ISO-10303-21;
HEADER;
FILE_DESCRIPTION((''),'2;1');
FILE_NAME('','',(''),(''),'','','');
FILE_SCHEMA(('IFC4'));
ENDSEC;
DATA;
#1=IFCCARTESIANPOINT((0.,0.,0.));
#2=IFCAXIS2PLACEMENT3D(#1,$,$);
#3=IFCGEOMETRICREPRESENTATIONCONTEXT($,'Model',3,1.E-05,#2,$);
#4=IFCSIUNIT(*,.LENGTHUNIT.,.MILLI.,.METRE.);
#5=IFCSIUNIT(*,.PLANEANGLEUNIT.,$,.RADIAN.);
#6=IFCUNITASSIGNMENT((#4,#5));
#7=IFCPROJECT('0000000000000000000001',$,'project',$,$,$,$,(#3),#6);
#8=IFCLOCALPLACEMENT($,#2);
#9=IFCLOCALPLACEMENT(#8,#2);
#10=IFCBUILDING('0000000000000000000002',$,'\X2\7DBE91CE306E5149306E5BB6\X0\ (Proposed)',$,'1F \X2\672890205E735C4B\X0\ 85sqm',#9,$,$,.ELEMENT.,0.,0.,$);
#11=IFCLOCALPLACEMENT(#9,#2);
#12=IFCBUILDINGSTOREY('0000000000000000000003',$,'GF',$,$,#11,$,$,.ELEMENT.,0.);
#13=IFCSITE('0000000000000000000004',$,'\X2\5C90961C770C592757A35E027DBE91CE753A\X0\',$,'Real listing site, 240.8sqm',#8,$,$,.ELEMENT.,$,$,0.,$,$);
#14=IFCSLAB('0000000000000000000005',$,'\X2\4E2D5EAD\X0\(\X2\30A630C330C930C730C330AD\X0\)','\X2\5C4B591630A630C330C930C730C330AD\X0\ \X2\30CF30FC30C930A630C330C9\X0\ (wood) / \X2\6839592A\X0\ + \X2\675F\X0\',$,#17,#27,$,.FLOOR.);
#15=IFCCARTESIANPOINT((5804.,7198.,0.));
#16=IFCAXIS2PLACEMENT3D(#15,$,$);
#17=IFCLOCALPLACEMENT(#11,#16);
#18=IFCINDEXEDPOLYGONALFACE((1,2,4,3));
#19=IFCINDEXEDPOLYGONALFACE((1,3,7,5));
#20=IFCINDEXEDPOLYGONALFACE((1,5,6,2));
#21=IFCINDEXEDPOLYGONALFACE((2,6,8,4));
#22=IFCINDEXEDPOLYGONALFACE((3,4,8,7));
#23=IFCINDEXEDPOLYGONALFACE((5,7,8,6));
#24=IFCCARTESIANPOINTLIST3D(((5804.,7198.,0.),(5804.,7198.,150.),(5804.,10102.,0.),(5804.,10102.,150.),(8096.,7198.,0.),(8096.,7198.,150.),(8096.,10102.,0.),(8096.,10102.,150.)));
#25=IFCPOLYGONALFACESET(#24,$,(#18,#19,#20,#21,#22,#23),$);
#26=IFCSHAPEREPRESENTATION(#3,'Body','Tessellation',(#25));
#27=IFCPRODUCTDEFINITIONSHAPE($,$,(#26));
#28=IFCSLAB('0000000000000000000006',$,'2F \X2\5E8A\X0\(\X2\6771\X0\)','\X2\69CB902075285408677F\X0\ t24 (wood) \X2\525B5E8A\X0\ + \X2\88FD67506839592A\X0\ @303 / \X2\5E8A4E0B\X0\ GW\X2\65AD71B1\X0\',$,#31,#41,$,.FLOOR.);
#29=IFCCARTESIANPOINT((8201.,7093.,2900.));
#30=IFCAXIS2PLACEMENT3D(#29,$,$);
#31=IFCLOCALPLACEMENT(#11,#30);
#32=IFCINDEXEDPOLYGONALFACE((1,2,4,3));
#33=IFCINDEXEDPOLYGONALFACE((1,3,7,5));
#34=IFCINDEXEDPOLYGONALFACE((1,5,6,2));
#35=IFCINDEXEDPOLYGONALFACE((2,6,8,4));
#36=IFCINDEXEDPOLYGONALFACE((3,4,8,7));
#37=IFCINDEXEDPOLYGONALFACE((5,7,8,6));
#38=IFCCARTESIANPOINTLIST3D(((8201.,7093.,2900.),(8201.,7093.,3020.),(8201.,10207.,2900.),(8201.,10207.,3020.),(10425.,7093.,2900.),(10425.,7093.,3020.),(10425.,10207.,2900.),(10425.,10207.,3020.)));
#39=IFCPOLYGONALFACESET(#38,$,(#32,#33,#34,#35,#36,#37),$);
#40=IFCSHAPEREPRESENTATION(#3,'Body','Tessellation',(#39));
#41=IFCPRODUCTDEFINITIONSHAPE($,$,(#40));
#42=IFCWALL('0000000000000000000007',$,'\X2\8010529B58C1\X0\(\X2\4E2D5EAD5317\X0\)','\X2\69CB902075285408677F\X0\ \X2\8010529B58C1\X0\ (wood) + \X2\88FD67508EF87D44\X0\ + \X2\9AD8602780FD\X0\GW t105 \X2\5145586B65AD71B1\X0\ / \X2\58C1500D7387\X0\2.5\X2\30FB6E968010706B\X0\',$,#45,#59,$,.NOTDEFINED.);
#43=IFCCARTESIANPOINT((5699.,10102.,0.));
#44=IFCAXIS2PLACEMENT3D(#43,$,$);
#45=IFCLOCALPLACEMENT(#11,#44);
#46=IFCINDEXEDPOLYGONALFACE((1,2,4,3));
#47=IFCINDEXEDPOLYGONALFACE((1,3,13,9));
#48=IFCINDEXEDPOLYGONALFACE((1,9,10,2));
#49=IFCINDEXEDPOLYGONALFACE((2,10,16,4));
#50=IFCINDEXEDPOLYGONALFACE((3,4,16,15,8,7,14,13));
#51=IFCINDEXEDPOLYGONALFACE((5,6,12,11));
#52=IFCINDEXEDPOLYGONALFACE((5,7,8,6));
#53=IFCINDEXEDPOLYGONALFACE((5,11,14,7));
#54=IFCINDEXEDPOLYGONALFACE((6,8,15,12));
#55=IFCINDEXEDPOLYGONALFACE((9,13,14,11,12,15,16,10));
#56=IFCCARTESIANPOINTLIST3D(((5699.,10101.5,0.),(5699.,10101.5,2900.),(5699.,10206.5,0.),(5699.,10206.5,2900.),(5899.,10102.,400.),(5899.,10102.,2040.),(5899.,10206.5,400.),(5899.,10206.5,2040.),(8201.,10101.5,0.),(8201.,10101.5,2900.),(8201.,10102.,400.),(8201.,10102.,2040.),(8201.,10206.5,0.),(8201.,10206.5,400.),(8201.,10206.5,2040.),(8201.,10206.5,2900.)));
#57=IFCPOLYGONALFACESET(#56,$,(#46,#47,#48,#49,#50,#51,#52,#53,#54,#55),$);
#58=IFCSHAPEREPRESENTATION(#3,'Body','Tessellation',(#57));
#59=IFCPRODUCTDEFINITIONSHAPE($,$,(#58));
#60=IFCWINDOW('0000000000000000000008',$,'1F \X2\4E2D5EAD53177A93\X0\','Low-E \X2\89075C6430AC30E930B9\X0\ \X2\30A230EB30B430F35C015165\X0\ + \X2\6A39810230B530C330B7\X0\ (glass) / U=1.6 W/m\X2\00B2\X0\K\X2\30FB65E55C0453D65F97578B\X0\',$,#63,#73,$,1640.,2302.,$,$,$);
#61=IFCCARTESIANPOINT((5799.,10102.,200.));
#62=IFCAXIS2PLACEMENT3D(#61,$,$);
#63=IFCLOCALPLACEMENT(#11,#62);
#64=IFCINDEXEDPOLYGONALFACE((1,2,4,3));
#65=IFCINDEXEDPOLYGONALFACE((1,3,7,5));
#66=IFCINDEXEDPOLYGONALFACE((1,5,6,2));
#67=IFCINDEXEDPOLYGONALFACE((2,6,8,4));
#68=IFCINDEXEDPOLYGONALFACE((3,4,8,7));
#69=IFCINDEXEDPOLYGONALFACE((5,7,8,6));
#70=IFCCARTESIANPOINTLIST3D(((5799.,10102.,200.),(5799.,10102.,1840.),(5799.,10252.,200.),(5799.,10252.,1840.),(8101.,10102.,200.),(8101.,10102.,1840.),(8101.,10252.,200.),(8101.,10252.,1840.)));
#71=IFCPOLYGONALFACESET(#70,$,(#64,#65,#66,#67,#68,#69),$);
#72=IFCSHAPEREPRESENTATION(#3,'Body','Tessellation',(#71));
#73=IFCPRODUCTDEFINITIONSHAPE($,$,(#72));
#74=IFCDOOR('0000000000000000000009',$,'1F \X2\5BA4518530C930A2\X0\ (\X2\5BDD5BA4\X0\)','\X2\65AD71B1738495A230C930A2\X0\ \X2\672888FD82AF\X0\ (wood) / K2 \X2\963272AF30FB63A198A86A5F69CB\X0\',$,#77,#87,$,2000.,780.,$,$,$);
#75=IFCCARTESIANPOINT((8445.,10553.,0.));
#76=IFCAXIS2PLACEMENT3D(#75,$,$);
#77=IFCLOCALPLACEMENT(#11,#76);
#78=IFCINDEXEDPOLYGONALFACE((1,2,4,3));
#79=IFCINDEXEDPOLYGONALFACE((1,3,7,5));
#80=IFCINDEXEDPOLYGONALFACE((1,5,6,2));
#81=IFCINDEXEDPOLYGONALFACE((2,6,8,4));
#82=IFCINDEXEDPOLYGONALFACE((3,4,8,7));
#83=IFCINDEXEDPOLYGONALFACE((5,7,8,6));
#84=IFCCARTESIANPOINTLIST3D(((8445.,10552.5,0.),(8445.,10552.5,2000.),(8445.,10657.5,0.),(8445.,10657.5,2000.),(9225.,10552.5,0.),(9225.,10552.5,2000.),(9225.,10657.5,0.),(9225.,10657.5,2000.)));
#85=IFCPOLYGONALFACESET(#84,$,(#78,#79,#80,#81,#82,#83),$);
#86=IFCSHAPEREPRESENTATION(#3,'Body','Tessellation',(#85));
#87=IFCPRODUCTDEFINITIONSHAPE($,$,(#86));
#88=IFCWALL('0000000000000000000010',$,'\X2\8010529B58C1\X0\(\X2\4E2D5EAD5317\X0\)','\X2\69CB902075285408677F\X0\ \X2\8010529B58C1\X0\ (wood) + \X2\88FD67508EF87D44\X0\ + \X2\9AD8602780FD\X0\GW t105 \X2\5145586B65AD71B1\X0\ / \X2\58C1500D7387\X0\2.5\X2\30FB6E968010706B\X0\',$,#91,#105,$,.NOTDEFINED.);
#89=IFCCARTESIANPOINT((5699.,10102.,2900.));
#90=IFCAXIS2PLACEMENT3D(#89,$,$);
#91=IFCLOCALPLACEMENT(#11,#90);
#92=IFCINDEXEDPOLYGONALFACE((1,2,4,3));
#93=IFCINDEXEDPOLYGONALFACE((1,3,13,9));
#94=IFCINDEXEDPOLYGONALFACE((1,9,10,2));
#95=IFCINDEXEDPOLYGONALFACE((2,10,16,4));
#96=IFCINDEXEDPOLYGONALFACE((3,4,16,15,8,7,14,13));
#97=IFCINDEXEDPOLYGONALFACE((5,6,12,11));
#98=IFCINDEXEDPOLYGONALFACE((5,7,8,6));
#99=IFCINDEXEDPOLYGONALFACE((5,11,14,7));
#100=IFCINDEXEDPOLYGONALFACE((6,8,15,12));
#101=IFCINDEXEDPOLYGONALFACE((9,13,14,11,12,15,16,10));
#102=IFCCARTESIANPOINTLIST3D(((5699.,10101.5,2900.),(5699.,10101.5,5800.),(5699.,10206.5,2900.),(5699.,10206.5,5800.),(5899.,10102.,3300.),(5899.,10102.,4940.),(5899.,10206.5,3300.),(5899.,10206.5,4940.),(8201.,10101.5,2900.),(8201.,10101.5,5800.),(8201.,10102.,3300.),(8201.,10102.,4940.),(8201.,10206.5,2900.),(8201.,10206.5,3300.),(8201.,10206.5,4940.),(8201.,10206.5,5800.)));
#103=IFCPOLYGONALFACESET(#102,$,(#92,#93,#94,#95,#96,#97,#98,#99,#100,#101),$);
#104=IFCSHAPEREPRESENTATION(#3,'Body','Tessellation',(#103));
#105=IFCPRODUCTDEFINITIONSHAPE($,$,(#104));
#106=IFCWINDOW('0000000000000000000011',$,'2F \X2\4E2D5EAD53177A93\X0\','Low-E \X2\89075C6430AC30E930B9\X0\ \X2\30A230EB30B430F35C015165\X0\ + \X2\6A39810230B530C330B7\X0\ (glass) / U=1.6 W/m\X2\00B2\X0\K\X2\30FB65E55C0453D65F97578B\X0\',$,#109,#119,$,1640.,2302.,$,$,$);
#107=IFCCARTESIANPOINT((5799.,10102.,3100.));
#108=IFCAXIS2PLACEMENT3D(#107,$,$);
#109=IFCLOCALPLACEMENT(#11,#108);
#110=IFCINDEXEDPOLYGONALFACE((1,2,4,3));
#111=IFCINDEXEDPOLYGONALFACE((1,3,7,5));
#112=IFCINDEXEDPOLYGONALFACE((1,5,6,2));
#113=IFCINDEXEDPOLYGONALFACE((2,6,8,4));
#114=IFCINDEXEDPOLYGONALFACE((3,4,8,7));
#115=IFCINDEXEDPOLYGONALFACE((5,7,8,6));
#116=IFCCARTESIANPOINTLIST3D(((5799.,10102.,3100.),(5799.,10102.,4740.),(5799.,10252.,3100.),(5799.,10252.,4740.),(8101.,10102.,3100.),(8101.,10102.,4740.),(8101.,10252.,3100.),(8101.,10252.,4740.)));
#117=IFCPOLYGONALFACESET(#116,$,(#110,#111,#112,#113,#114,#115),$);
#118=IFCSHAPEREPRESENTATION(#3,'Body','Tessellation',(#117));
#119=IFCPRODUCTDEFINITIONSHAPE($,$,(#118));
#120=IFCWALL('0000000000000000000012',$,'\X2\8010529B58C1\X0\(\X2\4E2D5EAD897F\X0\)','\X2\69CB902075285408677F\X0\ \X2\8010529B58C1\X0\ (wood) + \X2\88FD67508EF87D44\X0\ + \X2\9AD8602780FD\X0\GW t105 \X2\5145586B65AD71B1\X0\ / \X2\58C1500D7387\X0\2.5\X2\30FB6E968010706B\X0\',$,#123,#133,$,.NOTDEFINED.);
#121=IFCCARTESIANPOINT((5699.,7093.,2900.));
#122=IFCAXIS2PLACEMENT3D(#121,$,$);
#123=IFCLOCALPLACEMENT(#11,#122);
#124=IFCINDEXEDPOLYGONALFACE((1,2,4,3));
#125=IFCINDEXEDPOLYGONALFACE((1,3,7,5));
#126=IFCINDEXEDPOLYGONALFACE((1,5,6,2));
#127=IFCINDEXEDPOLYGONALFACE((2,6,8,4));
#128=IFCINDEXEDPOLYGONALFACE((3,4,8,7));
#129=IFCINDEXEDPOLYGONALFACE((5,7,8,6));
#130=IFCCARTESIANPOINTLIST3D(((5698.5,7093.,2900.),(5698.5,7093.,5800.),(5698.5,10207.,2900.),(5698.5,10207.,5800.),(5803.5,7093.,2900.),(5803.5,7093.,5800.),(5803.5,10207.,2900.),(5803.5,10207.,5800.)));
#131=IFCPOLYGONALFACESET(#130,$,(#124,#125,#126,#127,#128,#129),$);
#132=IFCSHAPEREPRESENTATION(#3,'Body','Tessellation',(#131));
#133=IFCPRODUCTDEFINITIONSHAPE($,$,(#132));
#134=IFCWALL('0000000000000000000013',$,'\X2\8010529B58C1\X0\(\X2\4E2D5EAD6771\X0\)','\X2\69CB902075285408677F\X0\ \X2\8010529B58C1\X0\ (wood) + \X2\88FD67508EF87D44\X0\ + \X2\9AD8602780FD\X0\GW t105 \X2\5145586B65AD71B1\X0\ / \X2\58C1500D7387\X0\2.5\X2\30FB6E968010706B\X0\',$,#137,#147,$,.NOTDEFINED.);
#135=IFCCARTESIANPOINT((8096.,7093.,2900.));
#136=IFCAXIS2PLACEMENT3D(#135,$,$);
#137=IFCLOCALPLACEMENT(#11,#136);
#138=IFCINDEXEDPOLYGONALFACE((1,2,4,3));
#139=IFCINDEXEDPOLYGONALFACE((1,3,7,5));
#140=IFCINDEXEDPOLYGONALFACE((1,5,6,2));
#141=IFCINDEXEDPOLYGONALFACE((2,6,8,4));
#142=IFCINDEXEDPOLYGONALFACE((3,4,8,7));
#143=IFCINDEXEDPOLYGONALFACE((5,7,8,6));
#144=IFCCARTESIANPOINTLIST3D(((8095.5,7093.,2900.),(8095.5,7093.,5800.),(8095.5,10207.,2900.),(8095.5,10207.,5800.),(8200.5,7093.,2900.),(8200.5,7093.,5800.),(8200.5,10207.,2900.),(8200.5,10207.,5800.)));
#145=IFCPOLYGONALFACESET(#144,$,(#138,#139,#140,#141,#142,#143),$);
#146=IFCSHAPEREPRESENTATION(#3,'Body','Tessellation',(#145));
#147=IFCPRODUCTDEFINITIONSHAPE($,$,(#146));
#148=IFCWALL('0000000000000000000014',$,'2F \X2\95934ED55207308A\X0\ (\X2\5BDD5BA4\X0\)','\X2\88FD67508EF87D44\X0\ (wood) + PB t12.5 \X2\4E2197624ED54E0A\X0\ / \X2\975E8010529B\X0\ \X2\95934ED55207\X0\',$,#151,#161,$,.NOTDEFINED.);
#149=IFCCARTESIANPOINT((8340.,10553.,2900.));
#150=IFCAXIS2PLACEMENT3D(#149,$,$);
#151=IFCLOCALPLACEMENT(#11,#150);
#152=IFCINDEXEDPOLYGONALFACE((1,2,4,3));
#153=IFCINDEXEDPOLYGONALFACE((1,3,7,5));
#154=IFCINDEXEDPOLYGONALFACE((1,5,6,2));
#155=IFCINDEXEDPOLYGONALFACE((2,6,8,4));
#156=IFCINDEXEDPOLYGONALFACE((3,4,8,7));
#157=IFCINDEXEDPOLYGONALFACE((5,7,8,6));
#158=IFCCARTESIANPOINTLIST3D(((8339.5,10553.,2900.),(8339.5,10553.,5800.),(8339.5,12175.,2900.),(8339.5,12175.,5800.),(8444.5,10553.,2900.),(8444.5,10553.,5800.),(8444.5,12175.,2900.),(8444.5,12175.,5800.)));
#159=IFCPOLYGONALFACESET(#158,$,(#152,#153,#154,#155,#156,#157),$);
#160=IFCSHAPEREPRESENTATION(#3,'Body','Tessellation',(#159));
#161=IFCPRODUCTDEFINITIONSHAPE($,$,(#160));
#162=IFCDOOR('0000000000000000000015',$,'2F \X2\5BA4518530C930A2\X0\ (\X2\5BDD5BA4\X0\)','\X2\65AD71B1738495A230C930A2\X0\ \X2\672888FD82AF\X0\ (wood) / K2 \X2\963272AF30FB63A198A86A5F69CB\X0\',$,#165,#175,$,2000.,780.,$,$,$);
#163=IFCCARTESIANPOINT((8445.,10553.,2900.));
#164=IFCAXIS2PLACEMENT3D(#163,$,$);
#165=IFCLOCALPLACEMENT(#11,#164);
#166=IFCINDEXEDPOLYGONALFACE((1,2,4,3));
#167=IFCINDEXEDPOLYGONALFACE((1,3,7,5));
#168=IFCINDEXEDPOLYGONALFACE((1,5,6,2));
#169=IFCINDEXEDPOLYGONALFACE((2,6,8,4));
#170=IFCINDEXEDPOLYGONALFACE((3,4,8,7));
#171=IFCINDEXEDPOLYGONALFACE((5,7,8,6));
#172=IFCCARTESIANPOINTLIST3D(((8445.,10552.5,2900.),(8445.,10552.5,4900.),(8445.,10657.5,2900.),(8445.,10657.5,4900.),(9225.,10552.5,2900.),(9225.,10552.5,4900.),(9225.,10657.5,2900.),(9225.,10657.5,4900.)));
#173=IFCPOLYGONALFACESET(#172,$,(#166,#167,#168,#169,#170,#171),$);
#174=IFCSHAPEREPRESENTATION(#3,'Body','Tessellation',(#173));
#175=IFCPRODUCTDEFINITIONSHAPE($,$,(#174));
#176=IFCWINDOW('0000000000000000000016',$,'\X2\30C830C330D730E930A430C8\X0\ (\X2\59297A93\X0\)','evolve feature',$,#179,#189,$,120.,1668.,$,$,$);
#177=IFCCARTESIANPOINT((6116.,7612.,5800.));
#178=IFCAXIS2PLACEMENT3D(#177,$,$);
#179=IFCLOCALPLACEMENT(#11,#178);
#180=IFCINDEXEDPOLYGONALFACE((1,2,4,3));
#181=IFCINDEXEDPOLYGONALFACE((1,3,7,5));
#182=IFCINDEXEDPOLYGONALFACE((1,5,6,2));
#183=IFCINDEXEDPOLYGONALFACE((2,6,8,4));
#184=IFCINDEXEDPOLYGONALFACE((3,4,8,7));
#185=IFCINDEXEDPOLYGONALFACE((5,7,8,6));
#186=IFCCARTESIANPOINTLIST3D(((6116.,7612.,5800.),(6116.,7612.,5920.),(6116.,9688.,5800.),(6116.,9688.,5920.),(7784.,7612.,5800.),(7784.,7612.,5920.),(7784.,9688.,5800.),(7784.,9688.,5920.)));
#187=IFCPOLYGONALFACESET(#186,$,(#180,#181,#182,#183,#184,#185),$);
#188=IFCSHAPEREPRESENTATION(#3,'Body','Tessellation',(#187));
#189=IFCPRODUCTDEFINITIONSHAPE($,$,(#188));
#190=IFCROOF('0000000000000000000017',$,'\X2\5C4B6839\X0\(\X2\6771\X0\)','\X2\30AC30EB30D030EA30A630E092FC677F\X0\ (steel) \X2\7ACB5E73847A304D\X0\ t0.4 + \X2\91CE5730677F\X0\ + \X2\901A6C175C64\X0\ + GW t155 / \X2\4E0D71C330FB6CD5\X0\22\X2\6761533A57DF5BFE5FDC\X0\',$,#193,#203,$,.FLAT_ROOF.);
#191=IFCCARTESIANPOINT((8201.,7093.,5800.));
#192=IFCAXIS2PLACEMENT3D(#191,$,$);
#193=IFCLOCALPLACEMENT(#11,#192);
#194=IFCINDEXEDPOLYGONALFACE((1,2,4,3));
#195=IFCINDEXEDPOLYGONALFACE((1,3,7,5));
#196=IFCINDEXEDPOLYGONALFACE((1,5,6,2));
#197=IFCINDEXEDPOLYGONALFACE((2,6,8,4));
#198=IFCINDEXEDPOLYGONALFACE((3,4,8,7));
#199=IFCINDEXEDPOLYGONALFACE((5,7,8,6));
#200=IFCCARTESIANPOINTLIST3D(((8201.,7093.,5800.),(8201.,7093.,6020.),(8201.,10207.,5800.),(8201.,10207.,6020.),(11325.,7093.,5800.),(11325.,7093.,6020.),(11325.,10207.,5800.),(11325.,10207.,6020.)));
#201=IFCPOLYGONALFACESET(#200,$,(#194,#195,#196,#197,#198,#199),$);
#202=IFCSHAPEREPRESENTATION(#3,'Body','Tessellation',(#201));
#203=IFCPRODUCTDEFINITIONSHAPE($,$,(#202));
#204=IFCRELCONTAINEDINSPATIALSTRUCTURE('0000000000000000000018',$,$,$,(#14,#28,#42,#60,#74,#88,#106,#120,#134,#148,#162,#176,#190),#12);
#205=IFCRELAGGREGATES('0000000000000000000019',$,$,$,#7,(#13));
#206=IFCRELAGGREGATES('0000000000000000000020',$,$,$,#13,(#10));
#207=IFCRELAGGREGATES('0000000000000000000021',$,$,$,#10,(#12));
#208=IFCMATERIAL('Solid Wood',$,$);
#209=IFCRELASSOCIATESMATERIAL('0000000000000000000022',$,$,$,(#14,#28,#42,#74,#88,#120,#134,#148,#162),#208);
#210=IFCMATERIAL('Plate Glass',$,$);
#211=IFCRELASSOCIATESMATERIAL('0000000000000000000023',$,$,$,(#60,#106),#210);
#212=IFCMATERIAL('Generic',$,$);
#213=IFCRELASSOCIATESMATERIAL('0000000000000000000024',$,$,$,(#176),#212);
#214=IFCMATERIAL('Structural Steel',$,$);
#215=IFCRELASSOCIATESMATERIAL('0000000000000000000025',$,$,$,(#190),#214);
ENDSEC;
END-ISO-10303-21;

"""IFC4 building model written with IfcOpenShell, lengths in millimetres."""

from ifc_helpers import new_model, si_unit, frame, frame_2d, origin, place, context, project, spatial, rectangle, extrude, material, element, fill, save


model = new_model("IFC4")

# Units and contexts
model_context = context("Model", 3, precision=1e-05, world=origin())
ifc_project = project(units=[si_unit("LENGTHUNIT", "METRE", prefix="MILLI"), si_unit("PLANEANGLEUNIT", "RADIAN")], contexts=[model_context])

# Site, building, storey
site_placement = place(None, origin())
site = spatial("IfcSite", under=ifc_project, at=site_placement, Name="岐阜県大垣市綾野町", ObjectType="Real listing site, 240.8sqm", CompositionType="ELEMENT", RefElevation=0.0)
building_placement = place(site_placement, origin())
building = spatial("IfcBuilding", under=site, at=building_placement, Name="綾野の光の家 (Proposed)", ObjectType="1F 木造平屋 85sqm", CompositionType="ELEMENT", ElevationOfRefHeight=0.0, ElevationOfTerrain=0.0)
storey_placement = place(building_placement, origin())
storey = spatial("IfcBuildingStorey", under=building, at=storey_placement, Name="GF", CompositionType="ELEMENT", Elevation=0.0)

# Slabs
ifc_material_1 = material(Name="Solid Wood")
slab_1_placement = place(storey_placement, frame((5804.0, 7198.0, 0.0)))
element("IfcSlab", 1, at=slab_1_placement, inside=storey, material=ifc_material_1, Name="中庭(ウッドデッキ)", Description="屋外ウッドデッキ ハードウッド (wood) / 根太 + 束", PredefinedType="FLOOR", context=model_context, shape_type="SweptSolid", body=[
    extrude(rectangle(XDim=2292.0, YDim=2904.0, at=frame_2d((1146.0, 1452.0))), frame((5804.0, 7198.0, 0.0)), (0.0, 0.0, 1.0), 150.0),
])
slab_2_placement = place(storey_placement, frame((8201.0, 7093.0, 2900.0)))
element("IfcSlab", 2, at=slab_2_placement, inside=storey, material=ifc_material_1, Name="2F 床(東)", Description="構造用合板 t24 (wood) 剛床 + 製材根太 @303 / 床下 GW断熱", PredefinedType="FLOOR", context=model_context, shape_type="SweptSolid", body=[
    extrude(rectangle(XDim=2224.0, YDim=3114.0, at=frame_2d((1112.0, 1557.0))), frame((8201.0, 7093.0, 2900.0)), (0.0, 0.0, 1.0), 120.0),
])

# Wall, opening, window
wall_1_placement = place(storey_placement, frame((5699.0, 10102.0, 0.0)))
wall_1 = element("IfcWall", 3, at=wall_1_placement, inside=storey, material=ifc_material_1, Name="耐力壁(中庭北)", Description="構造用合板 耐力壁 (wood) + 製材軸組 + 高性能GW t105 充填断熱 / 壁倍率2.5・準耐火", PredefinedType="NOTDEFINED", context=model_context, shape_type="SweptSolid", body=[
    extrude(rectangle(XDim=2502.0, YDim=105.0, at=frame_2d((1251.0, 52.0))), frame((5699.0, 10102.0, 0.0)), (0.0, 0.0, 1.0), 2900.0),
])
opening_1_placement = place(storey_placement, frame((5799.0, 10102.0, 200.0)))
opening_1 = element("IfcOpeningElement", 4, at=opening_1_placement, cuts=wall_1, PredefinedType="NOTDEFINED", context=model_context, shape_type="SweptSolid", body=[
    extrude(rectangle(XDim=2302.0, YDim=150.0, at=frame_2d((1151.0, 75.0))), frame((5799.0, 10102.0, 200.0)), (0.0, 0.0, 1.0), 1640.0),
])
ifc_material_2 = material(Name="Plate Glass")
window_1_placement = place(storey_placement, frame((5799.0, 10102.0, 200.0)))
window_1 = element("IfcWindow", 5, at=window_1_placement, inside=storey, material=ifc_material_2, Name="1F 中庭北窓", Description="Low-E 複層ガラス アルゴン封入 + 樹脂サッシ (glass) / U=1.6 W/m²K・日射取得型", OverallHeight=1640.0, OverallWidth=2302.0, context=model_context, shape_type="SweptSolid", body=[
    extrude(rectangle(XDim=2302.0, YDim=150.0, at=frame_2d((1151.0, 75.0))), frame((5799.0, 10102.0, 200.0)), (0.0, 0.0, 1.0), 1640.0),
])
fill(opening_1, window_1)

# Door
door_1_placement = place(storey_placement, frame((8445.0, 10553.0, 0.0)))
element("IfcDoor", 6, at=door_1_placement, inside=storey, material=ifc_material_1, Name="1F 室内ドア (寝室)", Description="断熱玄関ドア 木製芯 (wood) / K2 防犯・採風機構", OverallHeight=2000.0, OverallWidth=780.0, context=model_context, shape_type="SweptSolid", body=[
    extrude(rectangle(XDim=780.0, YDim=105.0, at=frame_2d((390.0, 52.0))), frame((8445.0, 10553.0, 0.0)), (0.0, 0.0, 1.0), 2000.0),
])

# Wall, opening, window
wall_2_placement = place(storey_placement, frame((5699.0, 10102.0, 2900.0)))
wall_2 = element("IfcWall", 7, at=wall_2_placement, inside=storey, material=ifc_material_1, Name="耐力壁(中庭北)", Description="構造用合板 耐力壁 (wood) + 製材軸組 + 高性能GW t105 充填断熱 / 壁倍率2.5・準耐火", PredefinedType="NOTDEFINED", context=model_context, shape_type="SweptSolid", body=[
    extrude(rectangle(XDim=2502.0, YDim=105.0, at=frame_2d((1251.0, 52.0))), frame((5699.0, 10102.0, 2900.0)), (0.0, 0.0, 1.0), 2900.0),
])
opening_2_placement = place(storey_placement, frame((5799.0, 10102.0, 3100.0)))
opening_2 = element("IfcOpeningElement", 8, at=opening_2_placement, cuts=wall_2, PredefinedType="NOTDEFINED", context=model_context, shape_type="SweptSolid", body=[
    extrude(rectangle(XDim=2302.0, YDim=150.0, at=frame_2d((1151.0, 75.0))), frame((5799.0, 10102.0, 3100.0)), (0.0, 0.0, 1.0), 1640.0),
])
window_2_placement = place(storey_placement, frame((5799.0, 10102.0, 3100.0)))
window_2 = element("IfcWindow", 9, at=window_2_placement, inside=storey, material=ifc_material_2, Name="2F 中庭北窓", Description="Low-E 複層ガラス アルゴン封入 + 樹脂サッシ (glass) / U=1.6 W/m²K・日射取得型", OverallHeight=1640.0, OverallWidth=2302.0, context=model_context, shape_type="SweptSolid", body=[
    extrude(rectangle(XDim=2302.0, YDim=150.0, at=frame_2d((1151.0, 75.0))), frame((5799.0, 10102.0, 3100.0)), (0.0, 0.0, 1.0), 1640.0),
])
fill(opening_2, window_2)

# Walls
wall_3_placement = place(storey_placement, frame((5699.0, 7093.0, 2900.0)))
element("IfcWall", 10, at=wall_3_placement, inside=storey, material=ifc_material_1, Name="耐力壁(中庭西)", Description="構造用合板 耐力壁 (wood) + 製材軸組 + 高性能GW t105 充填断熱 / 壁倍率2.5・準耐火", PredefinedType="NOTDEFINED", context=model_context, shape_type="SweptSolid", body=[
    extrude(rectangle(XDim=105.0, YDim=3114.0, at=frame_2d((52.0, 1557.0))), frame((5699.0, 7093.0, 2900.0)), (0.0, 0.0, 1.0), 2900.0),
])
wall_4_placement = place(storey_placement, frame((8096.0, 7093.0, 2900.0)))
element("IfcWall", 11, at=wall_4_placement, inside=storey, material=ifc_material_1, Name="耐力壁(中庭東)", Description="構造用合板 耐力壁 (wood) + 製材軸組 + 高性能GW t105 充填断熱 / 壁倍率2.5・準耐火", PredefinedType="NOTDEFINED", context=model_context, shape_type="SweptSolid", body=[
    extrude(rectangle(XDim=105.0, YDim=3114.0, at=frame_2d((52.0, 1557.0))), frame((8096.0, 7093.0, 2900.0)), (0.0, 0.0, 1.0), 2900.0),
])
wall_5_placement = place(storey_placement, frame((8340.0, 10553.0, 2900.0)))
element("IfcWall", 12, at=wall_5_placement, inside=storey, material=ifc_material_1, Name="2F 間仕切り (寝室)", Description="製材軸組 (wood) + PB t12.5 両面仕上 / 非耐力 間仕切", PredefinedType="NOTDEFINED", context=model_context, shape_type="SweptSolid", body=[
    extrude(rectangle(XDim=105.0, YDim=1622.0, at=frame_2d((52.0, 811.0))), frame((8340.0, 10553.0, 2900.0)), (0.0, 0.0, 1.0), 2900.0),
])

# Door
door_2_placement = place(storey_placement, frame((8445.0, 10553.0, 2900.0)))
element("IfcDoor", 13, at=door_2_placement, inside=storey, material=ifc_material_1, Name="2F 室内ドア (寝室)", Description="断熱玄関ドア 木製芯 (wood) / K2 防犯・採風機構", OverallHeight=2000.0, OverallWidth=780.0, context=model_context, shape_type="SweptSolid", body=[
    extrude(rectangle(XDim=780.0, YDim=105.0, at=frame_2d((390.0, 52.0))), frame((8445.0, 10553.0, 2900.0)), (0.0, 0.0, 1.0), 2000.0),
])

# Window
ifc_material_3 = material(Name="Generic")
window_3_placement = place(storey_placement, frame((6116.0, 7612.0, 5800.0)))
element("IfcWindow", 14, at=window_3_placement, inside=storey, material=ifc_material_3, Name="トップライト (天窓)", Description="evolve feature", OverallHeight=120.0, OverallWidth=1668.0, context=model_context, shape_type="SweptSolid", body=[
    extrude(rectangle(XDim=1668.0, YDim=2076.0, at=frame_2d((834.0, 1038.0))), frame((6116.0, 7612.0, 5800.0)), (0.0, 0.0, 1.0), 120.0),
])

# Roof
ifc_material_4 = material(Name="Structural Steel")
roof_placement = place(storey_placement, frame((8201.0, 7093.0, 5800.0)))
element("IfcRoof", 15, at=roof_placement, inside=storey, material=ifc_material_4, Name="屋根(東)", Description="ガルバリウム鋼板 (steel) 立平葺き t0.4 + 野地板 + 通気層 + GW t155 / 不燃・法22条区域対応", PredefinedType="FLAT_ROOF", context=model_context, shape_type="SweptSolid", body=[
    extrude(rectangle(XDim=3124.0, YDim=3114.0, at=frame_2d((1562.0, 1557.0))), frame((8201.0, 7093.0, 5800.0)), (0.0, 0.0, 1.0), 220.0),
])

save(model, "model.ifc")
